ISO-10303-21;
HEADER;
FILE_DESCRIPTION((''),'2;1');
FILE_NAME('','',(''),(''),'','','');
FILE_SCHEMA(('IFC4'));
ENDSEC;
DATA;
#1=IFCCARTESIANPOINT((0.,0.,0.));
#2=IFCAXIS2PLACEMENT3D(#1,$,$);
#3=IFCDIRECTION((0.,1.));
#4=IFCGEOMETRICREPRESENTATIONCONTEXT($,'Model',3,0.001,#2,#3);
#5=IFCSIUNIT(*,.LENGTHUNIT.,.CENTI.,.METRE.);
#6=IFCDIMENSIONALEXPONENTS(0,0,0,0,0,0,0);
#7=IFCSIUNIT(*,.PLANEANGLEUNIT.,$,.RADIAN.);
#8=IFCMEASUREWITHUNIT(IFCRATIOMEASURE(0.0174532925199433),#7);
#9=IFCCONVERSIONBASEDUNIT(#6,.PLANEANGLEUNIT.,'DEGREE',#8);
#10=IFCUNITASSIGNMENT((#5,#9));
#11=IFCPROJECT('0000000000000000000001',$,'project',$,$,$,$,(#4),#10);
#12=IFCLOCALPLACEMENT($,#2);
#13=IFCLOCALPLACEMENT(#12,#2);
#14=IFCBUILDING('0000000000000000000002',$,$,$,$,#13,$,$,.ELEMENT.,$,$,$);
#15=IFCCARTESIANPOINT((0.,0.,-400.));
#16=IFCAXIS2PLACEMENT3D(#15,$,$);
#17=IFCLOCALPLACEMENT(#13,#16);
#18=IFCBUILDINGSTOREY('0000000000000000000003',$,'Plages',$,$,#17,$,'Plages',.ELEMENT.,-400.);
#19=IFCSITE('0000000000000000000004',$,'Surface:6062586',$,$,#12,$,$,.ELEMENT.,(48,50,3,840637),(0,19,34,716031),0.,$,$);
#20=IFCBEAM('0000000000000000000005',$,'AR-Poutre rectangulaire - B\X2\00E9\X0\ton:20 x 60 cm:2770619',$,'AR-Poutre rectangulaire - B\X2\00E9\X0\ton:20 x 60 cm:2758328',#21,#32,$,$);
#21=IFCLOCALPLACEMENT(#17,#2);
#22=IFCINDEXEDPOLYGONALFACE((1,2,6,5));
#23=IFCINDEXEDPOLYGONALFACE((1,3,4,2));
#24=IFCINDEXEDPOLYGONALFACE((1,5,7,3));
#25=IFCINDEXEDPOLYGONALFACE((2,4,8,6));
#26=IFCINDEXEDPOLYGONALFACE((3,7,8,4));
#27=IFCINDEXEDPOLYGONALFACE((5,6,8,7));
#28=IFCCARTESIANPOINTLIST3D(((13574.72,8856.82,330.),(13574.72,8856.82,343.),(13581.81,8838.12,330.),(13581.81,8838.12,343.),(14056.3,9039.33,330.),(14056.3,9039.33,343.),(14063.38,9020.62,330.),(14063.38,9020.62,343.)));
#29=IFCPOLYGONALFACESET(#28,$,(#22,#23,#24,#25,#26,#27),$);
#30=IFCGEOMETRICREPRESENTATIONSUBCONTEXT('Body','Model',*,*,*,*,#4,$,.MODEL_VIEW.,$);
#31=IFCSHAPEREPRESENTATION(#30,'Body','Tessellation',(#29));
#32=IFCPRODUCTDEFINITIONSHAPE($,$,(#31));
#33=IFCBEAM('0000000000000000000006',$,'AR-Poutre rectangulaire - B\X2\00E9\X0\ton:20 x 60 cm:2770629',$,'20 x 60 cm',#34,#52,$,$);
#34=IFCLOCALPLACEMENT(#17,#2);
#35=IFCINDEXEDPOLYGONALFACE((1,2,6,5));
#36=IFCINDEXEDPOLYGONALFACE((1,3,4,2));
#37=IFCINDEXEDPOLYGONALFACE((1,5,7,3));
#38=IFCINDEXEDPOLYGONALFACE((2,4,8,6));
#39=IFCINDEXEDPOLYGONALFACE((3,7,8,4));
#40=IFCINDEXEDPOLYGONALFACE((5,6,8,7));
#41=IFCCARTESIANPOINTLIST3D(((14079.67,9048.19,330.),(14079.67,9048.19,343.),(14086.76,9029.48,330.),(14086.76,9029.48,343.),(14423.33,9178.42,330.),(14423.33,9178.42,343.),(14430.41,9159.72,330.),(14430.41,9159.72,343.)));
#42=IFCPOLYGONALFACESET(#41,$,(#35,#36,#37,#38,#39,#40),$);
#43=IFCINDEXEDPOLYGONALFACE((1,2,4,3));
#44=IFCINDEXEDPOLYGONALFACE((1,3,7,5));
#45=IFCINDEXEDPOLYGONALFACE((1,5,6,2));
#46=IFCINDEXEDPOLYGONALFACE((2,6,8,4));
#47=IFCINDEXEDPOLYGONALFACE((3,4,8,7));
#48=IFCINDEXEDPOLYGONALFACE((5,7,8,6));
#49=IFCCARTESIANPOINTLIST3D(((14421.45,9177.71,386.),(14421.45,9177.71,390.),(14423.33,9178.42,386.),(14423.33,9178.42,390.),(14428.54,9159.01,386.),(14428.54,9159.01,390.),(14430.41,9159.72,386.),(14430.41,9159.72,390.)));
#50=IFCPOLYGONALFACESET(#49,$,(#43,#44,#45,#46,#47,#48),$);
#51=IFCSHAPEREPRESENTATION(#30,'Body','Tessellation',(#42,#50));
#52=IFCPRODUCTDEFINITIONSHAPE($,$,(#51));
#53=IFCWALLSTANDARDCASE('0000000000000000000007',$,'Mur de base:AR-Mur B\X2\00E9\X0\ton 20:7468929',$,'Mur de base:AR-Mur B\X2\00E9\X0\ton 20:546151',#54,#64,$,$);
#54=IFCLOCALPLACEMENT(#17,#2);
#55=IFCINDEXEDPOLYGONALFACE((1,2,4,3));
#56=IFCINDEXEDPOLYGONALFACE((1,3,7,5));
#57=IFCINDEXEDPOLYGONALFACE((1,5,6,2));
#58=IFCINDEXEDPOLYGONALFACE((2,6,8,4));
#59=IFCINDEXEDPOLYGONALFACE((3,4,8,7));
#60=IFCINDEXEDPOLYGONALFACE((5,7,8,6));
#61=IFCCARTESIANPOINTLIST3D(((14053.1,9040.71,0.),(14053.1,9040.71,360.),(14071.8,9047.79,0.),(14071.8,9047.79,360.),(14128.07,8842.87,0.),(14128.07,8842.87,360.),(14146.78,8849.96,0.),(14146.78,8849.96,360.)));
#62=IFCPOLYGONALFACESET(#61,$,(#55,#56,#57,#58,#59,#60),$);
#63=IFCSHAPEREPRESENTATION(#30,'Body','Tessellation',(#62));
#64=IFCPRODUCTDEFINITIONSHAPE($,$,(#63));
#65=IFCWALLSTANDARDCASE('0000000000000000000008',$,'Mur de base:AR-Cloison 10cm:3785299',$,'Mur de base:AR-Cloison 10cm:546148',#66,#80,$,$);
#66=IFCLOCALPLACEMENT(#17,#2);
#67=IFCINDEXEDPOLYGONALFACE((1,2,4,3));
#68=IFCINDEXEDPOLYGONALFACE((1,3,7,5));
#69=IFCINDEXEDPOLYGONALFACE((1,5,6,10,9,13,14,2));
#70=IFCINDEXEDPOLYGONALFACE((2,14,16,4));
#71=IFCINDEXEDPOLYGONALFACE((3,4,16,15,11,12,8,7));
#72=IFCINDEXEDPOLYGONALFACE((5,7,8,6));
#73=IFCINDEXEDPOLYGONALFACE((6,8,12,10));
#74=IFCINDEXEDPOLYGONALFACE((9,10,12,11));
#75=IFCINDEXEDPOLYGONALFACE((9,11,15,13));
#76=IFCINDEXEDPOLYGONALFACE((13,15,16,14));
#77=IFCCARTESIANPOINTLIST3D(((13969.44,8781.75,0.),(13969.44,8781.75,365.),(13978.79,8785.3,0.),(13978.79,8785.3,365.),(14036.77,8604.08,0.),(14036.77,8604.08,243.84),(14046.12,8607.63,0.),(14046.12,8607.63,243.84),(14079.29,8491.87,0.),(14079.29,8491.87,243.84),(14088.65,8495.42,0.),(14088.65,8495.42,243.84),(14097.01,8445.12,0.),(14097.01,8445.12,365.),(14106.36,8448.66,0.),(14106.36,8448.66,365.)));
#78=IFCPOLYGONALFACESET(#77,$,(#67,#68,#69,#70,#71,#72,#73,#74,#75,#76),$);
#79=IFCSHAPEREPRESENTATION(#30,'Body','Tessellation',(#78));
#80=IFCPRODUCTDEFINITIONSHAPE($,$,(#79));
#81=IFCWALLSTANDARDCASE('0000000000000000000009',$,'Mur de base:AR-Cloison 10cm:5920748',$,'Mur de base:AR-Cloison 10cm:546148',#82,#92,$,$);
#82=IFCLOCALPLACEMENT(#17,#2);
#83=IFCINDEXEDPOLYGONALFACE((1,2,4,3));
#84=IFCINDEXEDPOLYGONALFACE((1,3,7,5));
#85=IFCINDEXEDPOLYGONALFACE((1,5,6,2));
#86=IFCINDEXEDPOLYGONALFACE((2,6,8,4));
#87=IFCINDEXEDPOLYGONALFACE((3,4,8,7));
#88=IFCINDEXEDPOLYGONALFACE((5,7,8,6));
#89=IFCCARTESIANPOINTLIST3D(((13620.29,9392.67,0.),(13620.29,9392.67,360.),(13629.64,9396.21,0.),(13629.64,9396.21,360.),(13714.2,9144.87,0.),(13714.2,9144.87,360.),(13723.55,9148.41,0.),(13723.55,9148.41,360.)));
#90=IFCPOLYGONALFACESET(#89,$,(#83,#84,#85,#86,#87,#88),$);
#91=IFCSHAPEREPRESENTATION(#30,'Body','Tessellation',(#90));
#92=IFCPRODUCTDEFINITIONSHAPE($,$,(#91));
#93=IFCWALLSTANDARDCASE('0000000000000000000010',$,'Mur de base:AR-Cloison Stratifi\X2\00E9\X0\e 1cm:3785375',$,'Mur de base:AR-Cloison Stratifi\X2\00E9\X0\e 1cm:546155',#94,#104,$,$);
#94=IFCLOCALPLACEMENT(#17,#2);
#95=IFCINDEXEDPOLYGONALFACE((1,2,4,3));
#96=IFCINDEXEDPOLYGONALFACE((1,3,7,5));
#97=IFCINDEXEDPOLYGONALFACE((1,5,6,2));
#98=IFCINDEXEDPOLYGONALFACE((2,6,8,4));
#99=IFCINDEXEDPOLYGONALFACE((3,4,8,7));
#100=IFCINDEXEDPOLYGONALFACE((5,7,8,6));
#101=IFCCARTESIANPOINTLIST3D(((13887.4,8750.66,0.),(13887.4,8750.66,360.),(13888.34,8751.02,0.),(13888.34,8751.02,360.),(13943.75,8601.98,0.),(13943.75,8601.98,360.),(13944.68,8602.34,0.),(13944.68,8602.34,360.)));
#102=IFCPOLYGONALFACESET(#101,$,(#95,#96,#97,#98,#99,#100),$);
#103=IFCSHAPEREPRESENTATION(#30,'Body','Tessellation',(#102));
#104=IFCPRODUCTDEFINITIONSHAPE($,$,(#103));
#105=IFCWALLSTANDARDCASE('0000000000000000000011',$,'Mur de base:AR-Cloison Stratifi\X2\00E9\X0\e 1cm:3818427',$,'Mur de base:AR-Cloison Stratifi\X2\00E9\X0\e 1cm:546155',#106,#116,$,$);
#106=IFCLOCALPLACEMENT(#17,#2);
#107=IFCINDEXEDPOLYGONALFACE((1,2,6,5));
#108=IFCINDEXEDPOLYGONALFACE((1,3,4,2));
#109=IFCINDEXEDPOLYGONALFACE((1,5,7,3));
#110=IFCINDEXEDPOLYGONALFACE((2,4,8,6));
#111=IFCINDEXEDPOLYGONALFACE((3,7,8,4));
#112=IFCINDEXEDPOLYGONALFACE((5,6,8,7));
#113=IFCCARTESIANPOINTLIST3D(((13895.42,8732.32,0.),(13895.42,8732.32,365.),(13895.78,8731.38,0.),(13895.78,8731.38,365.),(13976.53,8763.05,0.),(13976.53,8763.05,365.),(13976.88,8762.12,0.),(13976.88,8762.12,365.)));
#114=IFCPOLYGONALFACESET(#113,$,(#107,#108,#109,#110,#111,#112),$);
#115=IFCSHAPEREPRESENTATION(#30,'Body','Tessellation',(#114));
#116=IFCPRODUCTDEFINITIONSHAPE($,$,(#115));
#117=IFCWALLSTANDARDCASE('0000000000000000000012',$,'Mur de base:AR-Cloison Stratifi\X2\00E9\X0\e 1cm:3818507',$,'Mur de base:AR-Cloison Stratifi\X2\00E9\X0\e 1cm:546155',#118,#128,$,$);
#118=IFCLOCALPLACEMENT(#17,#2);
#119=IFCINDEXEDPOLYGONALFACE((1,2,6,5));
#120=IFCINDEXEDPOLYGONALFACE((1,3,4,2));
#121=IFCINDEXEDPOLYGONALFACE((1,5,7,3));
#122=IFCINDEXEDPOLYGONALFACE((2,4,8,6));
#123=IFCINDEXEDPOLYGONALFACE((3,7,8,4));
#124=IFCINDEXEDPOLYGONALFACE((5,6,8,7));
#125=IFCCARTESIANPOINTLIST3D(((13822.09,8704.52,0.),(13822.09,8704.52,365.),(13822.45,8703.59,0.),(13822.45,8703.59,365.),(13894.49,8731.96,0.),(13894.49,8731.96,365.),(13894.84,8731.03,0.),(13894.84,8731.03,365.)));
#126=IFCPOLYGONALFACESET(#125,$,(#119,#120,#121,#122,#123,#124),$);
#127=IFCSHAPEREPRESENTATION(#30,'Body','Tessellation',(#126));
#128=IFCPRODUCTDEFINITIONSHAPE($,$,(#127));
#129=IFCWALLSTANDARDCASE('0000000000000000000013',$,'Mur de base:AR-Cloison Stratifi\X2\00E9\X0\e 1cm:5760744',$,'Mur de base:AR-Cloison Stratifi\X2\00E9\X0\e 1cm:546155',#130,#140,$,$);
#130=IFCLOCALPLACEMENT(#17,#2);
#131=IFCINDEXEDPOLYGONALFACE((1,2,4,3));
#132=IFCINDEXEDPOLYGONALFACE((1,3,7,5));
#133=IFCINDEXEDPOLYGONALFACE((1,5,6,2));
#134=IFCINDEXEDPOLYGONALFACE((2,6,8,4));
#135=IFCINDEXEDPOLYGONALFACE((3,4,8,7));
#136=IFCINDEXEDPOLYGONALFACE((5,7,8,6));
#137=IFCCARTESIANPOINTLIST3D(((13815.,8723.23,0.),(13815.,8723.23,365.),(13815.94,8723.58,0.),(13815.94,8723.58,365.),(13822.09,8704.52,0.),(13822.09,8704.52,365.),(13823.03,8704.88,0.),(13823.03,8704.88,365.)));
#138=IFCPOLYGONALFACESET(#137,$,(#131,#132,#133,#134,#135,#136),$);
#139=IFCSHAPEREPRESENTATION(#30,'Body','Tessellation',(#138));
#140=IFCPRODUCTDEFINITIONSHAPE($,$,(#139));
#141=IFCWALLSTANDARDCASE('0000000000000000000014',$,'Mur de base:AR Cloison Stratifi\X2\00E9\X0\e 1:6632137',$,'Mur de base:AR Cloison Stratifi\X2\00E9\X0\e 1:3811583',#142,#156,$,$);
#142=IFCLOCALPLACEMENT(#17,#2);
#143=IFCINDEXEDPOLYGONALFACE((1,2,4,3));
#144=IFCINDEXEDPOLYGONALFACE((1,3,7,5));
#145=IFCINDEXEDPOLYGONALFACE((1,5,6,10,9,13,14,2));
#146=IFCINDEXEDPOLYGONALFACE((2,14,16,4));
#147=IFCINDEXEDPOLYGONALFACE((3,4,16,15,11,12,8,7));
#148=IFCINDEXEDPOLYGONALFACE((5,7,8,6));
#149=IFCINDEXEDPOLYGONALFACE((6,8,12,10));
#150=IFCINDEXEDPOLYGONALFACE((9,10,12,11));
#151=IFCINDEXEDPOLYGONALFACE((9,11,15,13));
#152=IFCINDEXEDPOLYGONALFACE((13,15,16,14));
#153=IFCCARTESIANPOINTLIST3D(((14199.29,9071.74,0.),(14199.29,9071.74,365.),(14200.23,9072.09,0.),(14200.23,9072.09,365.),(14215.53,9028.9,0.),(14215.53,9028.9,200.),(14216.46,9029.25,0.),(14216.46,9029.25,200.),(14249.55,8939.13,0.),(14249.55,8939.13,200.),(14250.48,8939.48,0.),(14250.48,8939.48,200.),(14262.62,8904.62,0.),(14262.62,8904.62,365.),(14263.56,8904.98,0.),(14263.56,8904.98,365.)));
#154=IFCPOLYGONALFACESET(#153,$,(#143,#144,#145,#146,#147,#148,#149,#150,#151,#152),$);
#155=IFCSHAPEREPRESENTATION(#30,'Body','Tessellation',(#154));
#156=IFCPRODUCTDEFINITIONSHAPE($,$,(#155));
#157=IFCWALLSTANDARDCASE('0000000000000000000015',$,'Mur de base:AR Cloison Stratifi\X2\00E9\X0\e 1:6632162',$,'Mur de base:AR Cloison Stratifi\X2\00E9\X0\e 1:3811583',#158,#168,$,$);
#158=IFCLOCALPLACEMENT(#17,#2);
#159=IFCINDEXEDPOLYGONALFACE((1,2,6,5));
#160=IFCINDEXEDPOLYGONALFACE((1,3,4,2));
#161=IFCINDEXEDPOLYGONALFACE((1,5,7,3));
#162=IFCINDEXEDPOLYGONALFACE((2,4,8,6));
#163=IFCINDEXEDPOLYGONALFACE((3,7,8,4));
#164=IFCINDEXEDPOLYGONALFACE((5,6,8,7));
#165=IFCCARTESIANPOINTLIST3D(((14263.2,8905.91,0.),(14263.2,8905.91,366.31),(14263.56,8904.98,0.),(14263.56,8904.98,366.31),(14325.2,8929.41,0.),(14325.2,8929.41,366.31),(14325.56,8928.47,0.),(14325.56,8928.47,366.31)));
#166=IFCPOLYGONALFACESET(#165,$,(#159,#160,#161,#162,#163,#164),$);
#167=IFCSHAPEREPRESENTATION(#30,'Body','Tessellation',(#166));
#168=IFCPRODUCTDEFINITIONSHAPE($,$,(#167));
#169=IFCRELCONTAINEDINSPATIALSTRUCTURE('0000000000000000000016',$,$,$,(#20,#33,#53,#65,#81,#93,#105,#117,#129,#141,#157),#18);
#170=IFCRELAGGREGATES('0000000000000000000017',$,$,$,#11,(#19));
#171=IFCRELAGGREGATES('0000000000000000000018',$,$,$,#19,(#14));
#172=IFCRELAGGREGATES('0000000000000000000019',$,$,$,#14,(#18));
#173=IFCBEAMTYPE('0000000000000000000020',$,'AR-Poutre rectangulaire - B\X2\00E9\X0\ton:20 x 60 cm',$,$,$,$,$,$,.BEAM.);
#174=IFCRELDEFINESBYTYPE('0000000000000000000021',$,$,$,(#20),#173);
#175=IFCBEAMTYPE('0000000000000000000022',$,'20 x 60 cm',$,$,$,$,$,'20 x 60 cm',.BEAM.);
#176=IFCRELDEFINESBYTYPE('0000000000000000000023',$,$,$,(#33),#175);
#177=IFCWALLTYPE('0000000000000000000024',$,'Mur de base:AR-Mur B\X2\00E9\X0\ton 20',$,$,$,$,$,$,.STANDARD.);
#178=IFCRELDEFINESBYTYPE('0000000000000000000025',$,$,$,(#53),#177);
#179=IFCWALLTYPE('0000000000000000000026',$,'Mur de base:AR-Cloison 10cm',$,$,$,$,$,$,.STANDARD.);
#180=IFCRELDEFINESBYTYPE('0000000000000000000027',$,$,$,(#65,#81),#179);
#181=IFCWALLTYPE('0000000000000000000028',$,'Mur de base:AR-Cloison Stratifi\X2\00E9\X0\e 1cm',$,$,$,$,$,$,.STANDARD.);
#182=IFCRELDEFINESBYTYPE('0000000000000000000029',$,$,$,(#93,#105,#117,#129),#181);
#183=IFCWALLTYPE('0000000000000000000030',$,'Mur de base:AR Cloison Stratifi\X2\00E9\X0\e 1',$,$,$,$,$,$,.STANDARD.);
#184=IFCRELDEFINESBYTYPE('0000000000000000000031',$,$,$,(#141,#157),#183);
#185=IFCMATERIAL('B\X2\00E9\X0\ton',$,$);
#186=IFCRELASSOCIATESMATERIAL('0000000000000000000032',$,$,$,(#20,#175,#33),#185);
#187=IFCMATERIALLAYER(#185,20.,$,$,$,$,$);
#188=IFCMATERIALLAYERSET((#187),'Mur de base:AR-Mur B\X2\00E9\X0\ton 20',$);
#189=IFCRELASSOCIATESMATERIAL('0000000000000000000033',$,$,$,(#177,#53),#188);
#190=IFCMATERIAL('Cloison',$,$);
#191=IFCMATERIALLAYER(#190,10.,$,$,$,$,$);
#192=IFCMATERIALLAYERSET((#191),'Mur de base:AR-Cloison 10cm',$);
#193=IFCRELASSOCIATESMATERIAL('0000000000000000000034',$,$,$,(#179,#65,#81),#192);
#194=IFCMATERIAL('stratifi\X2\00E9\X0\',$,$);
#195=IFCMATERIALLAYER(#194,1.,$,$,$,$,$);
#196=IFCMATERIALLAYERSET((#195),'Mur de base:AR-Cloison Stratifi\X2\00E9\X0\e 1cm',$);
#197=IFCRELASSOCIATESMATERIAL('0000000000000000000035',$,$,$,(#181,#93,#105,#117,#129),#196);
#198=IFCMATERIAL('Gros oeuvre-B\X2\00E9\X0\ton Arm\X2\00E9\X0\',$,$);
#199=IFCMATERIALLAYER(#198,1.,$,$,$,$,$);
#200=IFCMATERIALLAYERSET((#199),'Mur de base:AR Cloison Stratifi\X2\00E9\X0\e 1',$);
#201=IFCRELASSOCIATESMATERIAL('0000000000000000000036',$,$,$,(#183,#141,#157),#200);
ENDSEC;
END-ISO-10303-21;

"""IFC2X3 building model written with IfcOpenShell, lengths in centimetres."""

from ifc_helpers import new_model, entity, si_unit, converted_unit, direction, frame, frame_2d, origin, place, context, subcontext, project, spatial, rectangle, extrude, source, transform, mapped, material, layer, layer_set, layer_usage, type_object, type_shapes, element, save


model = new_model("IFC2X3")

# Units and contexts
model_context = context("Model", 3, precision=0.001, world=origin(), true_north=direction((0.0, 1.0)))
body_context = subcontext(model_context, "Body", "Model", "MODEL_VIEW")
ifc_project = project(units=[si_unit("LENGTHUNIT", "METRE", prefix="CENTI"), converted_unit("PLANEANGLEUNIT", "DEGREE", entity("IfcRatioMeasure", 0.0174532925199433), si_unit("PLANEANGLEUNIT", "RADIAN"), dimensions=[0, 0, 0, 0, 0, 0, 0])], contexts=[model_context])

# Site, building, storey
site_placement = place(None, origin())
site = spatial("IfcSite", under=ifc_project, at=site_placement, Name="Surface:6062586", CompositionType="ELEMENT", RefLatitude=(48, 50, 3, 840637), RefLongitude=(0, 19, 34, 716031), RefElevation=0.0)
building_placement = place(site_placement, origin())
building = spatial("IfcBuilding", under=site, at=building_placement, CompositionType="ELEMENT")
storey_placement = place(building_placement, frame((0.0, 0.0, -400.0)))
storey = spatial("IfcBuildingStorey", under=building, at=storey_placement, Name="Plages", LongName="Plages", CompositionType="ELEMENT", Elevation=-400.0)

# Beams
ifc_material_1 = material(Name="Béton")
beam_type_1 = type_object("IfcBeamType", Name="AR-Poutre rectangulaire - Béton:20 x 60 cm", PredefinedType="BEAM")
beam_1_placement = place(storey_placement, frame((14059.84, 9029.98, 390.0), z_axis=(0.0, 0.0, 1.0), x_axis=(-0.935103, -0.354376, 0.0)))
element("IfcBeam", 1, at=beam_1_placement, inside=storey, type_object=beam_type_1, material=ifc_material_1, Name="AR-Poutre rectangulaire - Béton:20 x 60 cm:2770619", ObjectType="AR-Poutre rectangulaire - Béton:20 x 60 cm:2758328", context=body_context, shape_type="SweptSolid", body=[
    extrude(rectangle(XDim=13.0, YDim=20.0, at=frame_2d((0.0, 0.0), x_axis=(1.0, 0.0))), frame((0.0, 0.0, -53.5), z_axis=(1.0, 0.0, 0.0), x_axis=(0.0, 0.0, -1.0)), (0.0, 0.0, 1.0), 515.0),
])
beam_type_2 = type_object("IfcBeamType", Name="20 x 60 cm", ElementType="20 x 60 cm", PredefinedType="BEAM", material=ifc_material_1)
shared_shape_1 = source(origin(), body_context, "Body", "SweptSolid", [
    extrude(rectangle(XDim=20.0, YDim=367.5, at=frame_2d((-2.0, 32.75), x_axis=(1.0, 0.0))), frame((205.28, 87.94, 0.0), z_axis=(0.0, 0.0, 1.0), x_axis=(-0.354376, 0.935103, 0.0)), (0.0, 0.0, 1.0), 13.0),
    extrude(rectangle(XDim=2.0, YDim=20.0, at=frame_2d((0.0, 0.0), x_axis=(1.0, 0.0))), frame((346.26, 139.23, 56.0), z_axis=(0.0, 0.0, 1.0), x_axis=(-0.935103, -0.354376, 0.0)), (0.0, 0.0, 1.0), 4.0),
])
type_shapes(beam_type_2, [shared_shape_1])
beam_2_placement = place(storey_placement, frame((14079.67, 9029.48, 330.0)))
element("IfcBeam", 2, at=beam_2_placement, inside=storey, type_object=beam_type_2, material=ifc_material_1, Name="AR-Poutre rectangulaire - Béton:20 x 60 cm:2770629", ObjectType="20 x 60 cm", context=body_context, shape_type="MappedRepresentation", body=[
    mapped(shared_shape_1, transform((0.0, 0.0, 0.0), scale=1.0)),
])

# Wall
ifc_layer_1 = layer(ifc_material_1, 20.0)
ifc_layer_set_1 = layer_set([ifc_layer_1], Name="Mur de base:AR-Mur Béton 20")
ifc_layer_usage_1 = layer_usage(ifc_layer_set_1, "AXIS2", "POSITIVE", -10.0)
wall_type_1 = type_object("IfcWallType", Name="Mur de base:AR-Mur Béton 20", PredefinedType="STANDARD", material=ifc_layer_set_1)
wall_1_placement = place(storey_placement, frame((14062.45, 9044.25, 0.0), z_axis=(0.0, 0.0, 1.0), x_axis=(0.354376, -0.935103, 0.0)))
element("IfcWallStandardCase", 3, at=wall_1_placement, inside=storey, type_object=wall_type_1, material=ifc_layer_usage_1, Name="Mur de base:AR-Mur Béton 20:7468929", ObjectType="Mur de base:AR-Mur Béton 20:546151", context=body_context, shape_type="SweptSolid", body=[
    extrude(rectangle(XDim=211.56, YDim=20.0, at=frame_2d((105.78, 0.0), x_axis=(-1.0, 0.0))), origin(), (0.0, 0.0, 1.0), 360.0),
])

# Wall, opening
ifc_material_2 = material(Name="Cloison")
ifc_layer_2 = layer(ifc_material_2, 10.0)
ifc_layer_set_2 = layer_set([ifc_layer_2], Name="Mur de base:AR-Cloison 10cm")
ifc_layer_usage_2 = layer_usage(ifc_layer_set_2, "AXIS2", "NEGATIVE", 5.0)
wall_type_2 = type_object("IfcWallType", Name="Mur de base:AR-Cloison 10cm", PredefinedType="STANDARD", material=ifc_layer_set_2)
wall_2_placement = place(storey_placement, frame((13974.11, 8783.53, 0.0), z_axis=(0.0, 0.0, 1.0), x_axis=(0.354376, -0.935103, 0.0)))
wall_2 = element("IfcWallStandardCase", 4, at=wall_2_placement, inside=storey, type_object=wall_type_2, material=ifc_layer_usage_2, Name="Mur de base:AR-Cloison 10cm:3785299", ObjectType="Mur de base:AR-Cloison 10cm:546148", context=body_context, shape_type="SweptSolid", body=[
    extrude(rectangle(XDim=360.0, YDim=10.0, at=frame_2d((180.0, 0.0), x_axis=(-1.0, 0.0))), origin(), (0.0, 0.0, 1.0), 365.0),
])
opening_1_placement = place(wall_2_placement, frame((294.93, -44.77, 0.0)))
element("IfcOpeningElement", 5, at=opening_1_placement, cuts=wall_2, ObjectType="Opening", context=body_context, shape_type="SweptSolid", body=[
    extrude(rectangle(XDim=243.84, YDim=120.0, at=frame_2d((0.0, 0.0), x_axis=(1.0, 0.0))), frame((-44.93, 39.77, 121.92), z_axis=(0.0, 1.0, 0.0), x_axis=(0.0, 0.0, -1.0)), (0.0, 0.0, 1.0), 10.0),
])

# Wall
ifc_layer_usage_3 = layer_usage(ifc_layer_set_2, "AXIS2", "NEGATIVE", 5.0)
wall_3_placement = place(storey_placement, frame((13718.87, 9146.64, 0.0), z_axis=(0.0, 0.0, 1.0), x_axis=(-0.354376, 0.935103, 0.0)))
element("IfcWallStandardCase", 6, at=wall_3_placement, inside=storey, type_object=wall_type_2, material=ifc_layer_usage_3, Name="Mur de base:AR-Cloison 10cm:5920748", ObjectType="Mur de base:AR-Cloison 10cm:546148", context=body_context, shape_type="SweptSolid", body=[
    extrude(rectangle(XDim=265.0, YDim=10.0, at=frame_2d((132.5, 0.0), x_axis=(-1.0, 0.0))), origin(), (0.0, 0.0, 1.0), 360.0),
])

# Walls
ifc_material_3 = material(Name="stratifié")
ifc_layer_3 = layer(ifc_material_3, 1.0)
ifc_layer_set_3 = layer_set([ifc_layer_3], Name="Mur de base:AR-Cloison Stratifiée 1cm")
ifc_layer_usage_4 = layer_usage(ifc_layer_set_3, "AXIS2", "NEGATIVE", 0.5)
wall_type_3 = type_object("IfcWallType", Name="Mur de base:AR-Cloison Stratifiée 1cm", PredefinedType="STANDARD", material=ifc_layer_set_3)
wall_4_placement = place(storey_placement, frame((13887.87, 8750.84, 0.0), z_axis=(0.0, 0.0, 1.0), x_axis=(0.354376, -0.935103, 0.0)))
element("IfcWallStandardCase", 7, at=wall_4_placement, inside=storey, type_object=wall_type_3, material=ifc_layer_usage_4, Name="Mur de base:AR-Cloison Stratifiée 1cm:3785375", ObjectType="Mur de base:AR-Cloison Stratifiée 1cm:546155", context=body_context, shape_type="SweptSolid", body=[
    extrude(rectangle(XDim=159.0, YDim=1.0, at=frame_2d((79.5, 0.0), x_axis=(-1.0, 0.0))), origin(), (0.0, 0.0, 1.0), 360.0),
])
ifc_layer_usage_5 = layer_usage(ifc_layer_set_3, "AXIS2", "NEGATIVE", 0.5)
wall_5_placement = place(storey_placement, frame((13895.6, 8731.85, 0.0), z_axis=(0.0, 0.0, 1.0), x_axis=(0.935103, 0.354376, 0.0)))
element("IfcWallStandardCase", 8, at=wall_5_placement, inside=storey, type_object=wall_type_3, material=ifc_layer_usage_5, Name="Mur de base:AR-Cloison Stratifiée 1cm:3818427", ObjectType="Mur de base:AR-Cloison Stratifiée 1cm:546155", context=body_context, shape_type="SweptSolid", body=[
    extrude(rectangle(XDim=86.73, YDim=1.0, at=frame_2d((43.37, 0.0), x_axis=(-1.0, 0.0))), origin(), (0.0, 0.0, 1.0), 365.0),
])
ifc_layer_usage_6 = layer_usage(ifc_layer_set_3, "AXIS2", "NEGATIVE", 0.5)
wall_6_placement = place(storey_placement, frame((13822.27, 8704.06, 0.0), z_axis=(0.0, 0.0, 1.0), x_axis=(0.935103, 0.354376, 0.0)))
element("IfcWallStandardCase", 9, at=wall_6_placement, inside=storey, type_object=wall_type_3, material=ifc_layer_usage_6, Name="Mur de base:AR-Cloison Stratifiée 1cm:3818507", ObjectType="Mur de base:AR-Cloison Stratifiée 1cm:546155", context=body_context, shape_type="SweptSolid", body=[
    extrude(rectangle(XDim=77.42, YDim=1.0, at=frame_2d((38.71, 0.0), x_axis=(-1.0, 0.0))), origin(), (0.0, 0.0, 1.0), 365.0),
])
ifc_layer_usage_7 = layer_usage(ifc_layer_set_3, "AXIS2", "NEGATIVE", 0.5)
wall_7_placement = place(storey_placement, frame((13822.56, 8704.7, 0.0), z_axis=(0.0, 0.0, 1.0), x_axis=(-0.354376, 0.935103, 0.0)))
element("IfcWallStandardCase", 10, at=wall_7_placement, inside=storey, type_object=wall_type_3, material=ifc_layer_usage_7, Name="Mur de base:AR-Cloison Stratifiée 1cm:5760744", ObjectType="Mur de base:AR-Cloison Stratifiée 1cm:546155", context=body_context, shape_type="SweptSolid", body=[
    extrude(rectangle(XDim=20.0, YDim=1.0, at=frame_2d((10.0, 0.0), x_axis=(-1.0, 0.0))), origin(), (0.0, 0.0, 1.0), 365.0),
])

# Wall, opening
ifc_material_4 = material(Name="Gros oeuvre-Béton Armé")
ifc_layer_4 = layer(ifc_material_4, 1.0)
ifc_layer_set_4 = layer_set([ifc_layer_4], Name="Mur de base:AR Cloison Stratifiée 1")
ifc_layer_usage_8 = layer_usage(ifc_layer_set_4, "AXIS2", "NEGATIVE", 0.5)
wall_type_4 = type_object("IfcWallType", Name="Mur de base:AR Cloison Stratifiée 1", PredefinedType="STANDARD", material=ifc_layer_set_4)
wall_8_placement = place(storey_placement, frame((14199.76, 9071.92, 0.0), z_axis=(0.0, 0.0, 1.0), x_axis=(0.354377, -0.935103, 0.0)))
wall_8 = element("IfcWallStandardCase", 11, at=wall_8_placement, inside=storey, type_object=wall_type_4, material=ifc_layer_usage_8, Name="Mur de base:AR Cloison Stratifiée 1:6632137", ObjectType="Mur de base:AR Cloison Stratifiée 1:3811583", context=body_context, shape_type="SweptSolid", body=[
    extrude(rectangle(XDim=178.71, YDim=1.0, at=frame_2d((89.36, 0.0), x_axis=(-1.0, 0.0))), origin(), (0.0, 0.0, 1.0), 365.0),
])
opening_2_placement = place(wall_8_placement, frame((141.82, 0.5, 0.0)))
element("IfcOpeningElement", 12, at=opening_2_placement, cuts=wall_8, ObjectType="Opening", context=body_context, shape_type="SweptSolid", body=[
    extrude(rectangle(XDim=200.0, YDim=96.0, at=frame_2d((100.0, 48.0), x_axis=(1.0, 0.0))), frame((0.0, 0.0, 0.0), z_axis=(0.0, -1.0, 0.0), x_axis=(0.0, 0.0, 1.0)), (0.0, 0.0, 1.0), 1.0),
])

# Wall
ifc_layer_usage_9 = layer_usage(ifc_layer_set_4, "AXIS2", "NEGATIVE", 0.5)
wall_9_placement = place(storey_placement, frame((14263.38, 8905.45, 0.0), z_axis=(0.0, 0.0, 1.0), x_axis=(0.935103, 0.354377, 0.0)))
element("IfcWallStandardCase", 13, at=wall_9_placement, inside=storey, type_object=wall_type_4, material=ifc_layer_usage_9, Name="Mur de base:AR Cloison Stratifiée 1:6632162", ObjectType="Mur de base:AR Cloison Stratifiée 1:3811583", context=body_context, shape_type="SweptSolid", body=[
    extrude(rectangle(XDim=66.3, YDim=1.0, at=frame_2d((33.15, 0.0), x_axis=(-1.0, 0.0))), origin(), (0.0, 0.0, 1.0), 366.31),
])

save(model, "model.ifc")
